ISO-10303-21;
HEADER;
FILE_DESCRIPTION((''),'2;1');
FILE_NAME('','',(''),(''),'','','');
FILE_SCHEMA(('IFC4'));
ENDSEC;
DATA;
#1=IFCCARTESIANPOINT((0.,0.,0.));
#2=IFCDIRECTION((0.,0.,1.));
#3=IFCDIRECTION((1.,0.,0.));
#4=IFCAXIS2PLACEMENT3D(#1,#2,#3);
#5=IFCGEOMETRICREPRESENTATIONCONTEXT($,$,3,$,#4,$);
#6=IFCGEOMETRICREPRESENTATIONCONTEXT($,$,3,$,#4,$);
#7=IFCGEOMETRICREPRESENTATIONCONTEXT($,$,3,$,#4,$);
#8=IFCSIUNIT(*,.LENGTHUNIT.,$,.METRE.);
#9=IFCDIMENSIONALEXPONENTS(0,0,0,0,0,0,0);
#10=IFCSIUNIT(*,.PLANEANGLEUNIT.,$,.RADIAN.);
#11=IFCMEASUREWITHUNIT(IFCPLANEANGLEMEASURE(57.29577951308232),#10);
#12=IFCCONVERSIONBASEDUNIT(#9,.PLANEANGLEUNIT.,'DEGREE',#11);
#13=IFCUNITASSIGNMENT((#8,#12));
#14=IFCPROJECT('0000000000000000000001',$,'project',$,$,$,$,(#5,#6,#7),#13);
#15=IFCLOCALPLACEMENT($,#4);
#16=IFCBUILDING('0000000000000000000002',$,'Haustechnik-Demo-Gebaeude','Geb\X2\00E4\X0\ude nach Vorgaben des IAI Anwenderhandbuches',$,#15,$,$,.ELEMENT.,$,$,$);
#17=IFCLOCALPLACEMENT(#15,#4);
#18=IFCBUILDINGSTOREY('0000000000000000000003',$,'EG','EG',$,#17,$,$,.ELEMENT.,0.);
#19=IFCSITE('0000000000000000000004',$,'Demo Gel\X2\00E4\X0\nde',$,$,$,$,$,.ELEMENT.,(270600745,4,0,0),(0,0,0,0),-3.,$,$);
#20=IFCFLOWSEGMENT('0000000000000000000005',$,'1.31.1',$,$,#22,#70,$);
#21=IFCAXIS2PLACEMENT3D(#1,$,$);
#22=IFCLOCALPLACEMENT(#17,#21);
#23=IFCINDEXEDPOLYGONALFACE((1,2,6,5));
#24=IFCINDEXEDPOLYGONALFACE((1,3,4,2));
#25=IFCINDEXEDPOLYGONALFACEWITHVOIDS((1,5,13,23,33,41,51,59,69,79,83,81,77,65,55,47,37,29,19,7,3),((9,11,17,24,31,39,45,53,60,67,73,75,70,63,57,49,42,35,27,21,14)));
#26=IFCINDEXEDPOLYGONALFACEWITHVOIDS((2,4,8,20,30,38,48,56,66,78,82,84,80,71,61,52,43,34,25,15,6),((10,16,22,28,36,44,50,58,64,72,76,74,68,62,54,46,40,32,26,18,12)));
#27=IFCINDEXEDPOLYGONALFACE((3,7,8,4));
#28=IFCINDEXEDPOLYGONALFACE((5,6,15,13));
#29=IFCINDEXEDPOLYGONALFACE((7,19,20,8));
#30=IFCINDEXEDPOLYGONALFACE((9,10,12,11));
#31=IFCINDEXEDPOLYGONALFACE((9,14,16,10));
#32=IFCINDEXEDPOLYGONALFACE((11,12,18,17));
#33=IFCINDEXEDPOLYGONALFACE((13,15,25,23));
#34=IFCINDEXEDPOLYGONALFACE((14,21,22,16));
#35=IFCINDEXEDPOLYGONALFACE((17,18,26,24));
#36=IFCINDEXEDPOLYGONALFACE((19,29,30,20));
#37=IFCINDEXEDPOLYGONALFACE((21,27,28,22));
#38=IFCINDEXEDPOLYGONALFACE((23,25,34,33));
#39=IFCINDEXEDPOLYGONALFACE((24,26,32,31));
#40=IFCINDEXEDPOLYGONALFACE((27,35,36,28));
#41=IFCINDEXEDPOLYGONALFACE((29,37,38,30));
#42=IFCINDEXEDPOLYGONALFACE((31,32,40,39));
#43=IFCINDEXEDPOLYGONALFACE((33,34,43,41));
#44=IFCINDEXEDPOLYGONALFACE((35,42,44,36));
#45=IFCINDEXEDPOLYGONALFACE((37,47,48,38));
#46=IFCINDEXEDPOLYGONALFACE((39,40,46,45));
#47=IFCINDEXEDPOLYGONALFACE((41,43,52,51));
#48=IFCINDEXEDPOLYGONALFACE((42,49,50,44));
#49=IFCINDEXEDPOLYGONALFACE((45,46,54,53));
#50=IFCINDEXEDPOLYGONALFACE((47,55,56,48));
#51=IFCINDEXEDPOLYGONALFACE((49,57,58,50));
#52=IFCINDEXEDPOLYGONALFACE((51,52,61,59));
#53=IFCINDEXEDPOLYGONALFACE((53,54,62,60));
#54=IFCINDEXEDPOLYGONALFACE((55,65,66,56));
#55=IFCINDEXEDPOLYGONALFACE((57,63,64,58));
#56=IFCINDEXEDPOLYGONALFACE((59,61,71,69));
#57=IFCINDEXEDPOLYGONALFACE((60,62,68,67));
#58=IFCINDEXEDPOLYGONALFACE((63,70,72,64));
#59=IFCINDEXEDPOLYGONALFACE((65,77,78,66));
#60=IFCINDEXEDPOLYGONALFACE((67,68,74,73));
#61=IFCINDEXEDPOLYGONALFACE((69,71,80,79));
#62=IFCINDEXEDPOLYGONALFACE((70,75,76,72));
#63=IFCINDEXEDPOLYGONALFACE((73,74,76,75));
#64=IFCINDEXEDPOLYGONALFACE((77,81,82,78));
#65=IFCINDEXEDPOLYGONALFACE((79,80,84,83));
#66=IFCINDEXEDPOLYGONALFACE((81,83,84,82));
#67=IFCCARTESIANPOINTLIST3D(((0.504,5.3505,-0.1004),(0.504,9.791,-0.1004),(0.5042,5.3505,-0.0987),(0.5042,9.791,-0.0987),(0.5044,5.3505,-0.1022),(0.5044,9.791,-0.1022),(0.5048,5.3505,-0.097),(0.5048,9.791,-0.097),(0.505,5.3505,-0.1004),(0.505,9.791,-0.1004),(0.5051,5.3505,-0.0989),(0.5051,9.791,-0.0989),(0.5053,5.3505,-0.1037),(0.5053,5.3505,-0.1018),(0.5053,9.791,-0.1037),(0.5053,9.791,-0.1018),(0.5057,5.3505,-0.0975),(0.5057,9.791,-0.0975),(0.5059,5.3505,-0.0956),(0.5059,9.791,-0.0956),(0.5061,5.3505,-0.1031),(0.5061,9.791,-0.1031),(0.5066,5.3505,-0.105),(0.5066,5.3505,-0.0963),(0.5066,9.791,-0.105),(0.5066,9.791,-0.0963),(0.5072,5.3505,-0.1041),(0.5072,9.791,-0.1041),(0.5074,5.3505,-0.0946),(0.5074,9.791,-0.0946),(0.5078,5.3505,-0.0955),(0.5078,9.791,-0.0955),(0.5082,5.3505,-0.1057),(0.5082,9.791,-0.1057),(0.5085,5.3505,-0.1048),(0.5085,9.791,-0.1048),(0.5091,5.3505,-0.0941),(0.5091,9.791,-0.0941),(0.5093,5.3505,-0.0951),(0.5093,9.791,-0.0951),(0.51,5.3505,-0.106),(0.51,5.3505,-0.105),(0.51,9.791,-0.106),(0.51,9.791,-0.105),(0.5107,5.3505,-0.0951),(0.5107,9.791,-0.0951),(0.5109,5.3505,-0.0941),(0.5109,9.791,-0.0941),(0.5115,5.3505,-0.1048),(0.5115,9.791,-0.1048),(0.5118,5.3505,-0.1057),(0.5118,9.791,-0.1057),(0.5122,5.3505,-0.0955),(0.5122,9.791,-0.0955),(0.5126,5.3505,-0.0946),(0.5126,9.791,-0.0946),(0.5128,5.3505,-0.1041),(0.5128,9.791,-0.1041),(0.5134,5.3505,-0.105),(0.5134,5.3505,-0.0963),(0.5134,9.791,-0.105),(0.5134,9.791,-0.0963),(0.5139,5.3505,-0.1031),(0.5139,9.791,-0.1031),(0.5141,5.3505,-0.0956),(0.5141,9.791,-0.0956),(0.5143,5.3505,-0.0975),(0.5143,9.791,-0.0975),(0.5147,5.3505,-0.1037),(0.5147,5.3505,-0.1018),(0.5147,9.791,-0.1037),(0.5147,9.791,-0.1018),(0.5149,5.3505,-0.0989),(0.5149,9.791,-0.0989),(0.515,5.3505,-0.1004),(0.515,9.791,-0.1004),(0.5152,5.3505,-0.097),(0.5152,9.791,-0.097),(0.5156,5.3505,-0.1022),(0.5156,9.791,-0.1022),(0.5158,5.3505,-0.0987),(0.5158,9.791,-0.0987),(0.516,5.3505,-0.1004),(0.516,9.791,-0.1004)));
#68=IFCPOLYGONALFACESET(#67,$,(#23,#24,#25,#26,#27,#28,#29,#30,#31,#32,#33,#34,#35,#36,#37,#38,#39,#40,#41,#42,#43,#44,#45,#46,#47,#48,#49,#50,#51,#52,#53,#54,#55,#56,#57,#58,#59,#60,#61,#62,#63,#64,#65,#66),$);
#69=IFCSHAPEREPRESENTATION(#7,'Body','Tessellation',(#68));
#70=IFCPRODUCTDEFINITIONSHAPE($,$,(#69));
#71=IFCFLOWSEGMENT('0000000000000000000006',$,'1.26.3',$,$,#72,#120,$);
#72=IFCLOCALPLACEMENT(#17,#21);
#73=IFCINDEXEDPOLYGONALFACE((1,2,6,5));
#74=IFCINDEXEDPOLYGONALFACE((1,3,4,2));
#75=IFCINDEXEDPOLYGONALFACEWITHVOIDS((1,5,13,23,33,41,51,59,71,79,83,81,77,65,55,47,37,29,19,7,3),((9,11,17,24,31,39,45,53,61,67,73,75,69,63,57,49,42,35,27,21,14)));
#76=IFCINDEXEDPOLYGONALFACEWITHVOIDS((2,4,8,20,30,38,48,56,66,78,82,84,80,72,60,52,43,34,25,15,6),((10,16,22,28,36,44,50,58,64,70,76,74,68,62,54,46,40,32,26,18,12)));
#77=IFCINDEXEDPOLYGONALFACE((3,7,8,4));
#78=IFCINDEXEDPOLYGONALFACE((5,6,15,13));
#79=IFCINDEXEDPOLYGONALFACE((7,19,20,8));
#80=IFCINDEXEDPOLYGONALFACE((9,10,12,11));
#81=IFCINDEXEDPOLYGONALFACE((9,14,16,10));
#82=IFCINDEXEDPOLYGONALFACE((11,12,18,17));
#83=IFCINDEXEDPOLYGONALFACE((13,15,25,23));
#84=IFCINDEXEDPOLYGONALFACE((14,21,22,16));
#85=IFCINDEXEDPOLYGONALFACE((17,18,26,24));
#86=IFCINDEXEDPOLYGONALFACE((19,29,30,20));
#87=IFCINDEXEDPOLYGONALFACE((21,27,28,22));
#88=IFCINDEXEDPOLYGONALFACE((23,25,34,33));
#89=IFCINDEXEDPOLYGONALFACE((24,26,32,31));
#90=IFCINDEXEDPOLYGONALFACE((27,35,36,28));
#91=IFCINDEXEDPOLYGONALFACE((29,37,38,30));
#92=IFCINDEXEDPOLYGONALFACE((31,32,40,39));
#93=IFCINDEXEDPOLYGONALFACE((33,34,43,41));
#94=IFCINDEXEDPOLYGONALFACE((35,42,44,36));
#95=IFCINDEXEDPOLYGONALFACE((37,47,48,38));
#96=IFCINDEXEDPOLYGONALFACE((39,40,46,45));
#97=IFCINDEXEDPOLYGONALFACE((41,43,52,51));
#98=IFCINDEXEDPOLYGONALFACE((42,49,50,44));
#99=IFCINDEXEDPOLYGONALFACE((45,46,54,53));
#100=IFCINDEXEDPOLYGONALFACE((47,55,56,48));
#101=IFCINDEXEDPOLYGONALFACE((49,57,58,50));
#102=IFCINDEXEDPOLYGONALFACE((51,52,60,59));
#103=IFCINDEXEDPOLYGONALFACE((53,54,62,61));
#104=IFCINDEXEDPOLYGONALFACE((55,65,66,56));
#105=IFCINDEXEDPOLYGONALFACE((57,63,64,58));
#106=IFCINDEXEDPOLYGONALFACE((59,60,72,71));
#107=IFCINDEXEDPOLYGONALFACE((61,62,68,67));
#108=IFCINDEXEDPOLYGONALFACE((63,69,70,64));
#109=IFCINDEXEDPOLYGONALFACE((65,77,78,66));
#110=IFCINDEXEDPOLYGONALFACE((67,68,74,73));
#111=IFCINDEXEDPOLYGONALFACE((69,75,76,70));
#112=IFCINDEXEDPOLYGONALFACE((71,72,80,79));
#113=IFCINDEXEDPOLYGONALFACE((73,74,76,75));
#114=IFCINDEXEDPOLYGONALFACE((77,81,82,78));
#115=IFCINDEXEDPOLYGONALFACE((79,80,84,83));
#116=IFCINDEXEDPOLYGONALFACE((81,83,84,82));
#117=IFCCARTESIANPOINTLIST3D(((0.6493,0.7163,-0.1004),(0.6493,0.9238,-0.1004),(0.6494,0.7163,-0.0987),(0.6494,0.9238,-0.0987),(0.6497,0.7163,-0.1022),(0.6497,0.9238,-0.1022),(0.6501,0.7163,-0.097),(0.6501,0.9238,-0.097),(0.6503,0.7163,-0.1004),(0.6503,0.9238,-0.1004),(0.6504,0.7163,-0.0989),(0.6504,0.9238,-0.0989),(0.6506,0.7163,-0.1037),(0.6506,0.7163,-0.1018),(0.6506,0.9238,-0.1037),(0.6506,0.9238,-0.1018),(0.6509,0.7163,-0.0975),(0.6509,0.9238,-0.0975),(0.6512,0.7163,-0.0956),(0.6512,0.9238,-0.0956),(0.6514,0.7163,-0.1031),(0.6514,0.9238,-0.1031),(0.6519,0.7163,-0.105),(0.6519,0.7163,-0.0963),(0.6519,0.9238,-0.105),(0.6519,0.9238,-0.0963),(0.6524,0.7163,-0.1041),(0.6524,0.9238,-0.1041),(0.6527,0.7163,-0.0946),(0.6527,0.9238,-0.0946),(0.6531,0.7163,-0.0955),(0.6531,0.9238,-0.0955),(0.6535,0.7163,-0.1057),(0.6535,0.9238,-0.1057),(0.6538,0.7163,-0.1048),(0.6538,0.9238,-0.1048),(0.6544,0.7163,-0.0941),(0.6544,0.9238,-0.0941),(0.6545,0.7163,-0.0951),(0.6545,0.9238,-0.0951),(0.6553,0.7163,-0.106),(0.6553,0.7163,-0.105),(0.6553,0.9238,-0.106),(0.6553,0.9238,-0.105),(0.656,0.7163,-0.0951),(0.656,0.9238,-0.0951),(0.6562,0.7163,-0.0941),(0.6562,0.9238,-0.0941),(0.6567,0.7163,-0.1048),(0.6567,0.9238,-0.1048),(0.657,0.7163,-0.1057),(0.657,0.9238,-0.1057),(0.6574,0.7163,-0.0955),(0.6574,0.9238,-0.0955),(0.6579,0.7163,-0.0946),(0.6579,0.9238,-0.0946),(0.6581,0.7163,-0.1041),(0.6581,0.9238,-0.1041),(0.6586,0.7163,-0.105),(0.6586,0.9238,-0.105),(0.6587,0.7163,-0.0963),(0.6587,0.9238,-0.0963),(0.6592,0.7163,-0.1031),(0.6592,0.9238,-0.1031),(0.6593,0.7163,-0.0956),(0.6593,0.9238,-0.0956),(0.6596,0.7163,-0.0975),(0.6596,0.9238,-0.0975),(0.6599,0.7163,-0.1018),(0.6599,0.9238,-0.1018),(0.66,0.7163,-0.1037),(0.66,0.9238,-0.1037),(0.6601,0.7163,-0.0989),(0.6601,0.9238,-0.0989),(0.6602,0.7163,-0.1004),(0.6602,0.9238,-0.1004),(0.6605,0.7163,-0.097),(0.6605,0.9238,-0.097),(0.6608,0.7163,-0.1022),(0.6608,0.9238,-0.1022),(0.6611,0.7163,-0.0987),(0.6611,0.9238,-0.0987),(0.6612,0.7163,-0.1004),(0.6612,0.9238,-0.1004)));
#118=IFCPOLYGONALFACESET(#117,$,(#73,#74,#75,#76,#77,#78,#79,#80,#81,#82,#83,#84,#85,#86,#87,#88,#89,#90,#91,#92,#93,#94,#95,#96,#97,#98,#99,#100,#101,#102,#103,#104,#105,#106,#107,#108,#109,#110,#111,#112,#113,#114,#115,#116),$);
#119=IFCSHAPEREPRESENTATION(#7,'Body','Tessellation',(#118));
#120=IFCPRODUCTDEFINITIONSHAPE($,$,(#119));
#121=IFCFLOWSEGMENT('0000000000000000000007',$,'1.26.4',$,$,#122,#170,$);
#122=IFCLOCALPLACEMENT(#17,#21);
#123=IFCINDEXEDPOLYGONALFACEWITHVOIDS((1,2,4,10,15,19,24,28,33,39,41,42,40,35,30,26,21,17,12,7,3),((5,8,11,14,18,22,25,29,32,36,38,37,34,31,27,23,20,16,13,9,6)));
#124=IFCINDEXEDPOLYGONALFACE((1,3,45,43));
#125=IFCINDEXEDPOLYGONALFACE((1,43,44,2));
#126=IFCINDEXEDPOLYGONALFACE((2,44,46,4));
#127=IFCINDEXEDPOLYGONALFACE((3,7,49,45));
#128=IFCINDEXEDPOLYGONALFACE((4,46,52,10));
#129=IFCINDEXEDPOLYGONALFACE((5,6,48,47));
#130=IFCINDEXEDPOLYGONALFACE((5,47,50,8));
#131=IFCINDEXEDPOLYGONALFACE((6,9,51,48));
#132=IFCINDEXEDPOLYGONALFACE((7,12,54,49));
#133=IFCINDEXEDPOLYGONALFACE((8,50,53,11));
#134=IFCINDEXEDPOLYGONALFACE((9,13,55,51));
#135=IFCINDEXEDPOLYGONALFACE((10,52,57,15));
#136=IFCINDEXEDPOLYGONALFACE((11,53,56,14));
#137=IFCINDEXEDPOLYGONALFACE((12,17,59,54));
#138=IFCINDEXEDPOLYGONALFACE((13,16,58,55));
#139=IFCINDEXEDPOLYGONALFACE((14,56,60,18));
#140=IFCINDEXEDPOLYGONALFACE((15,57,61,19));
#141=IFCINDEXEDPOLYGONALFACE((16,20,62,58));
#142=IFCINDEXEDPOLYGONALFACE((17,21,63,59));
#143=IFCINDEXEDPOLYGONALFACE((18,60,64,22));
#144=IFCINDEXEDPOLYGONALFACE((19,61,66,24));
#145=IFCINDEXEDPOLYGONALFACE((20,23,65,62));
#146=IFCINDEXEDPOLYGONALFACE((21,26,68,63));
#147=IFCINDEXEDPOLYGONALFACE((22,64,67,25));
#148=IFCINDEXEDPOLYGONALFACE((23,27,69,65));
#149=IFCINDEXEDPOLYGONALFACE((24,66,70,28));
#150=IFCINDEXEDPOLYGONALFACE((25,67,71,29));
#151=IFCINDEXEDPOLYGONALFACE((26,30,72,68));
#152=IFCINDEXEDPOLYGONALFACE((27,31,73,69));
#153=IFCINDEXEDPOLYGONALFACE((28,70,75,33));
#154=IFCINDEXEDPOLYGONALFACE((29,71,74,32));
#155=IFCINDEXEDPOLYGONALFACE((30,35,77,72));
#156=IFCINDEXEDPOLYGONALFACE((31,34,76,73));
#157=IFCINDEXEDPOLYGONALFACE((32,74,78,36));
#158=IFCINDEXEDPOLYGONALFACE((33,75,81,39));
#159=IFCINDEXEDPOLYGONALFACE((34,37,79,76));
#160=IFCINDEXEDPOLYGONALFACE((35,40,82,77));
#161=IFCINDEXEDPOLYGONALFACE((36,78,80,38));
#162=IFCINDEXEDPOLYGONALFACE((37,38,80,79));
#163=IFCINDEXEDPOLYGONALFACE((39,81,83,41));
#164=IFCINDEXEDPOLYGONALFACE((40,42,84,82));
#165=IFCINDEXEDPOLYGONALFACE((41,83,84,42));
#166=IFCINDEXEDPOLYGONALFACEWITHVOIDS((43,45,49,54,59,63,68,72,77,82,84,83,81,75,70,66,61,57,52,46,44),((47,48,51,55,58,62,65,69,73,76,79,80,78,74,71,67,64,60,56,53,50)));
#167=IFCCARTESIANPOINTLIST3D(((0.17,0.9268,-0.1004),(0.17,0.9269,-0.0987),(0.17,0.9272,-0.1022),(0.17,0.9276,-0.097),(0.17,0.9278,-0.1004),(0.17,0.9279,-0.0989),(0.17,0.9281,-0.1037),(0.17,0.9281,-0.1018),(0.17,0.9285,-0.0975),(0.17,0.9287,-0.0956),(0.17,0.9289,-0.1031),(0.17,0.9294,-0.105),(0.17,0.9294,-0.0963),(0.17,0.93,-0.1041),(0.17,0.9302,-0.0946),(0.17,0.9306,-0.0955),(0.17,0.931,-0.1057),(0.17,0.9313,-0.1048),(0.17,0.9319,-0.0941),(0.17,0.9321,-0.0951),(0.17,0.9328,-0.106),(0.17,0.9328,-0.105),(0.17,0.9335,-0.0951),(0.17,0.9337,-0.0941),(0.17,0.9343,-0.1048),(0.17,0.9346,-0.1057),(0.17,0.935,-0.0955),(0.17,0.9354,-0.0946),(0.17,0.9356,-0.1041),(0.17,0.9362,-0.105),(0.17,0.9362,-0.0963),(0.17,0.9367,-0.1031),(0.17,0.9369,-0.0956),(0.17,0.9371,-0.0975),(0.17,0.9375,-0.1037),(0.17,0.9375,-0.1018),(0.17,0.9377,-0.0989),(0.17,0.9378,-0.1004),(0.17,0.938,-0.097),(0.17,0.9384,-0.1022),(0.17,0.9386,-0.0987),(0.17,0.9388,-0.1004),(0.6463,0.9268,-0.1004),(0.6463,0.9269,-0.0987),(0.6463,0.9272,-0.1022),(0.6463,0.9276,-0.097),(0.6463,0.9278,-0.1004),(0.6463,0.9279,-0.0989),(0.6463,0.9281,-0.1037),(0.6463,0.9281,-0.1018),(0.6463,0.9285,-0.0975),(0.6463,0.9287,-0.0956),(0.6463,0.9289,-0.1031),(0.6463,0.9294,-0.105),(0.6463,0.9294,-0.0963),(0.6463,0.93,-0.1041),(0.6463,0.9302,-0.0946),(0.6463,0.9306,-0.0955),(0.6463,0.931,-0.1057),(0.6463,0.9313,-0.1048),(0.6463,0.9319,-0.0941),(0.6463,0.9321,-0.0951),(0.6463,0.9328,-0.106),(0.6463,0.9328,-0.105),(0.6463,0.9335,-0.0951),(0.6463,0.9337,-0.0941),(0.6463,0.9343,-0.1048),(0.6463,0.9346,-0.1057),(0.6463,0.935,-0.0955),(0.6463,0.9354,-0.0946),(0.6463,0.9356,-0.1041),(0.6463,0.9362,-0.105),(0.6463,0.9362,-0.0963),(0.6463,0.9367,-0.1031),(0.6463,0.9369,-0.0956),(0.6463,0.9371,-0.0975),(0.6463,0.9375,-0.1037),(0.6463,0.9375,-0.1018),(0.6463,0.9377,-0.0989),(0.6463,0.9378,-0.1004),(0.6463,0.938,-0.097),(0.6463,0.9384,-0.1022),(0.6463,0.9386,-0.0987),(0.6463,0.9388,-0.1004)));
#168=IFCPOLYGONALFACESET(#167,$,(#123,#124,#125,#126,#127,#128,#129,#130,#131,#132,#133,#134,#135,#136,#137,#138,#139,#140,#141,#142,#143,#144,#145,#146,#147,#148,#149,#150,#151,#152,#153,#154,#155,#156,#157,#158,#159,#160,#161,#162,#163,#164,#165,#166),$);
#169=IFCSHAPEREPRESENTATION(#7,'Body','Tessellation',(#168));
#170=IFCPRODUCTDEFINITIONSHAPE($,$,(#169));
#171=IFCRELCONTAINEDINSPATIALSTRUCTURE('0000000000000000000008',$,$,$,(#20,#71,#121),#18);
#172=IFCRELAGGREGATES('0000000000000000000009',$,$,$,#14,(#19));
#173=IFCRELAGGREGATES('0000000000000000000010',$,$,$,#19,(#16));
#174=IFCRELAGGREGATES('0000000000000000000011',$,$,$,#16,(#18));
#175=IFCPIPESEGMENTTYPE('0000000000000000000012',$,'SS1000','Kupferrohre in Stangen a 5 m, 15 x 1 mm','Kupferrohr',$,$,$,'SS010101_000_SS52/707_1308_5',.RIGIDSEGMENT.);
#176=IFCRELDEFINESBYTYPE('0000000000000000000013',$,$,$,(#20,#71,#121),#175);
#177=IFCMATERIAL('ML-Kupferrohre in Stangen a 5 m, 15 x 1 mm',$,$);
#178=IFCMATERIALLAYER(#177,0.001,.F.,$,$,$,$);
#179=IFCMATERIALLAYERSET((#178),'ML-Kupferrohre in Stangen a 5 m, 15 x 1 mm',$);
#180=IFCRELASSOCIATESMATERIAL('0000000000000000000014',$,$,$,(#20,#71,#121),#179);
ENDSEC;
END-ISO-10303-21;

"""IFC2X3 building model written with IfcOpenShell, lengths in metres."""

from ifc_helpers import new_model, entity, si_unit, converted_unit, frame, origin_with_axes, origin_2d_with_axis, place, context, project, spatial, hollow_circle, extrude, material, layer, layer_set, layer_usage, type_object, element, save


model = new_model("IFC2X3")

# Units and contexts
context_of_model_1 = context(None, 3, world=origin_with_axes())
context_of_model_2 = context(None, 3, world=origin_with_axes())
context_of_model_3 = context(None, 3, world=origin_with_axes())
ifc_project = project(units=[si_unit("LENGTHUNIT", "METRE"), converted_unit("PLANEANGLEUNIT", "DEGREE", entity("IfcPlaneAngleMeasure", 57.29577951308232), si_unit("PLANEANGLEUNIT", "RADIAN"), dimensions=[0, 0, 0, 0, 0, 0, 0])], contexts=[context_of_model_1, context_of_model_2, context_of_model_3])

# Site, building, storey
site = spatial("IfcSite", under=ifc_project, Name="Demo Gelände", CompositionType="ELEMENT", RefLatitude=(270600745, 4, 0, 0), RefLongitude=(0, 0, 0, 0), RefElevation=-3.0)
building_placement = place(None, origin_with_axes())
building = spatial("IfcBuilding", under=site, at=building_placement, Name="Haustechnik-Demo-Gebaeude", Description="Gebäude nach Vorgaben des IAI Anwenderhandbuches", CompositionType="ELEMENT")
storey_placement = place(building_placement, origin_with_axes())
storey = spatial("IfcBuildingStorey", under=building, at=storey_placement, Name="EG", Description="EG", CompositionType="ELEMENT", Elevation=0.0)

# Flow segments
ifc_material = material(Name="ML-Kupferrohre in Stangen a 5 m, 15 x 1 mm")
ifc_layer = layer(ifc_material, 0.001, ventilated=False)
ifc_layer_set = layer_set([ifc_layer], Name="ML-Kupferrohre in Stangen a 5 m, 15 x 1 mm")
ifc_layer_usage = layer_usage(ifc_layer_set, "AXIS2", "POSITIVE", 0.0)
pipe_segment_type_1 = type_object("IfcPipeSegmentType", Name="SS1000", Description="Kupferrohre in Stangen a 5 m, 15 x 1 mm", ApplicableOccurrence="Kupferrohr", ElementType="SS010101_000_SS52/707_1308_5", PredefinedType="RIGIDSEGMENT")
flow_segment_1_placement = place(storey_placement, frame((0.51, 5.3505, -0.1), z_axis=(0.0, 1.0, 0.0), x_axis=(0.0, 0.0, -1.0)))
element("IfcFlowSegment", 1, at=flow_segment_1_placement, inside=storey, type_object=pipe_segment_type_1, material=ifc_layer_usage, Name="1.31.1", context=context_of_model_3, shape_type="SweptSolid", body=[
    extrude(hollow_circle(Radius=0.006, WallThickness=0.001, at=origin_2d_with_axis()), origin_with_axes(), (0.0, 0.0, 1.0), 4.4405),
])
flow_segment_2_placement = place(storey_placement, frame((0.6553, 0.7163, -0.1), z_axis=(0.0, 1.0, 0.0), x_axis=(0.0, 0.0, -1.0)))
element("IfcFlowSegment", 2, at=flow_segment_2_placement, inside=storey, type_object=pipe_segment_type_1, material=ifc_layer_usage, Name="1.26.3", context=context_of_model_3, shape_type="SweptSolid", body=[
    extrude(hollow_circle(Radius=0.006, WallThickness=0.001, at=origin_2d_with_axis()), origin_with_axes(), (0.0, 0.0, 1.0), 0.2075),
])
flow_segment_3_placement = place(storey_placement, frame((0.6463, 0.9328, -0.1), z_axis=(-1.0, 0.0, 0.0), x_axis=(0.0, 0.0, -1.0)))
element("IfcFlowSegment", 3, at=flow_segment_3_placement, inside=storey, type_object=pipe_segment_type_1, material=ifc_layer_usage, Name="1.26.4", context=context_of_model_3, shape_type="SweptSolid", body=[
    extrude(hollow_circle(Radius=0.006, WallThickness=0.001, at=origin_2d_with_axis()), origin_with_axes(), (0.0, 0.0, 1.0), 0.4763),
])

save(model, "model.ifc")
